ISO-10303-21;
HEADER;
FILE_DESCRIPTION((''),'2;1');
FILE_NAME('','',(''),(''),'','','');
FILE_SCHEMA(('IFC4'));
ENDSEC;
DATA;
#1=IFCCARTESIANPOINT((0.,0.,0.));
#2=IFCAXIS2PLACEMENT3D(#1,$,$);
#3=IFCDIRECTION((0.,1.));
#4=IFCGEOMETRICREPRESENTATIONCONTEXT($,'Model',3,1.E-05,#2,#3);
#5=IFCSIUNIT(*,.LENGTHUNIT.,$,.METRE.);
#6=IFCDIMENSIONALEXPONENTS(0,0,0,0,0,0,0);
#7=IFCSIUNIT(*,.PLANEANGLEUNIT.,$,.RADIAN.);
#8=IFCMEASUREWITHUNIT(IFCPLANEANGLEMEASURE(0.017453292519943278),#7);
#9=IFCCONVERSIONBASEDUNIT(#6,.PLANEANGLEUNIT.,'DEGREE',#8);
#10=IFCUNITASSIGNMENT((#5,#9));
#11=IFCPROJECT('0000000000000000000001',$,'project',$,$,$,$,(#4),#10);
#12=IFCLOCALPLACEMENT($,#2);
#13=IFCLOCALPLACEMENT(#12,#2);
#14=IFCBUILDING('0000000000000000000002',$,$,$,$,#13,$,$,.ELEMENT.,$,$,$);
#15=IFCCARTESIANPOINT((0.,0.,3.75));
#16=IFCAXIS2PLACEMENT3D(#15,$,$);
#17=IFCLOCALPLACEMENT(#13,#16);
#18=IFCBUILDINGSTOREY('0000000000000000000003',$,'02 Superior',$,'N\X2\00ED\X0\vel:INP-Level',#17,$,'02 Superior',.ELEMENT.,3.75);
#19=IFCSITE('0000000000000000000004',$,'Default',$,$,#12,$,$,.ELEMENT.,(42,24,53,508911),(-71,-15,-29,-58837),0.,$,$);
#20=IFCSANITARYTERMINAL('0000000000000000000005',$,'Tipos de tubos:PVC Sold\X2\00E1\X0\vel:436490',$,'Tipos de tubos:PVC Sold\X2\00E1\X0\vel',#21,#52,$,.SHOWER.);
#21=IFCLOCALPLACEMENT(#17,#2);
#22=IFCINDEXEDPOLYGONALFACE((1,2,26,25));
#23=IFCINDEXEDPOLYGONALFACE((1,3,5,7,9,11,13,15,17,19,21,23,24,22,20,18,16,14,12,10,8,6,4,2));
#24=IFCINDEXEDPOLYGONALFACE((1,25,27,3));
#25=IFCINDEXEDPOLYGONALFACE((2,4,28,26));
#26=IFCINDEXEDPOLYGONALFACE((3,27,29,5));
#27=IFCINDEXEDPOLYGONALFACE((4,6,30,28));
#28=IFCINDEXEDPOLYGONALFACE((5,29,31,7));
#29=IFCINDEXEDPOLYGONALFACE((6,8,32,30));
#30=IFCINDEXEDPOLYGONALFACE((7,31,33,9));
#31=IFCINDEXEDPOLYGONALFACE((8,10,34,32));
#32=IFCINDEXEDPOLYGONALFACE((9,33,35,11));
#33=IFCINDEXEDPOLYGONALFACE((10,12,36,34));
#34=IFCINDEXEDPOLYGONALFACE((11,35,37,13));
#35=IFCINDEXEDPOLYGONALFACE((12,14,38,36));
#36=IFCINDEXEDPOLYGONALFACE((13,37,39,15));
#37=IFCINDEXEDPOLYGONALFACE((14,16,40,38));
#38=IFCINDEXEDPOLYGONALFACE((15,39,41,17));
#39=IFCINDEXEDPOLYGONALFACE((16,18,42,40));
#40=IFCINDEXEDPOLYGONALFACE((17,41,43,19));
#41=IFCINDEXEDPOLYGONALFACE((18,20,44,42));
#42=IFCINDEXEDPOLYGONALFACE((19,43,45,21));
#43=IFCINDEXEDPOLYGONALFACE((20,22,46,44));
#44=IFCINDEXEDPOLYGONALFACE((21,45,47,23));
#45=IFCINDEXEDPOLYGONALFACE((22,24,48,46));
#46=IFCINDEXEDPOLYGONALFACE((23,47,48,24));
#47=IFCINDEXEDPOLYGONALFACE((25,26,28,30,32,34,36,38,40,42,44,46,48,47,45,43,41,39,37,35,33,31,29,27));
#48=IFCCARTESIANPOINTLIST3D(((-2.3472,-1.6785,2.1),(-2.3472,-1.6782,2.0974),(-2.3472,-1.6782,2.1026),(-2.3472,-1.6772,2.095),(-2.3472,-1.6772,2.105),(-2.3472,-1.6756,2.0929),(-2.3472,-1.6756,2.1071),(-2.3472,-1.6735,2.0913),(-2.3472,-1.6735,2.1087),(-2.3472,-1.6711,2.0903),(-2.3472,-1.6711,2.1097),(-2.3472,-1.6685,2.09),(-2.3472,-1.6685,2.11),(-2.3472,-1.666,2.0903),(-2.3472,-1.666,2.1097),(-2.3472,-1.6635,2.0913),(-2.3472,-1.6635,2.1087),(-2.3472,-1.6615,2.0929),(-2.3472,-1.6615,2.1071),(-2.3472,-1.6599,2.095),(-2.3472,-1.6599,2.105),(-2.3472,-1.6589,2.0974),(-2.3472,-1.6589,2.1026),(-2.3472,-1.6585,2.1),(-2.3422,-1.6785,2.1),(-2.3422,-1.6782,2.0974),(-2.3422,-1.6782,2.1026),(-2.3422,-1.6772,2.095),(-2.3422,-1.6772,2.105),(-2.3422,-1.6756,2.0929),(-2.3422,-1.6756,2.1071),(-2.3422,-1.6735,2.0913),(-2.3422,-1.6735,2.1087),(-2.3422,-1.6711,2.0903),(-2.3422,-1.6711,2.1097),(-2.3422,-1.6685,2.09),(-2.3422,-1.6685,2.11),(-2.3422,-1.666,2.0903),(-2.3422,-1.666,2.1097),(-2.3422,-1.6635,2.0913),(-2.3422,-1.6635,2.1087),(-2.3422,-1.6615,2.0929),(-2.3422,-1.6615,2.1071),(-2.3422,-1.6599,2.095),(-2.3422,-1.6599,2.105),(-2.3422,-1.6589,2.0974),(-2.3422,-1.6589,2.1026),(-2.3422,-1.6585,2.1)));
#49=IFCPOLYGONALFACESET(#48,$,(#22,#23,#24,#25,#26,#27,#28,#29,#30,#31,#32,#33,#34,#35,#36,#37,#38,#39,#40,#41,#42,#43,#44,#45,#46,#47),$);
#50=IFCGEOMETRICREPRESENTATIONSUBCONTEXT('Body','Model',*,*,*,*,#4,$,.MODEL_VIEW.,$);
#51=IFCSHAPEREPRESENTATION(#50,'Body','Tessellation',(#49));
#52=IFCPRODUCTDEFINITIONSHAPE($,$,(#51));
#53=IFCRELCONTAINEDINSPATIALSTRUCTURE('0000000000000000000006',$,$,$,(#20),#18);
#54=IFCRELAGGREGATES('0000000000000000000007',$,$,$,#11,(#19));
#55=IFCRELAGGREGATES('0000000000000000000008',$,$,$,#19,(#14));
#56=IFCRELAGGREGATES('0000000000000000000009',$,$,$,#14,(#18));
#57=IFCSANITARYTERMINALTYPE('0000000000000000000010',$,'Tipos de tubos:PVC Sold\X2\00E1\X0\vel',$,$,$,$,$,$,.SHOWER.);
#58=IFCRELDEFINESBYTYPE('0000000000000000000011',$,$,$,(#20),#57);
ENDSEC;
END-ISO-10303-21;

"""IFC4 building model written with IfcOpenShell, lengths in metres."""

from ifc_helpers import new_model, entity, si_unit, converted_unit, direction, frame, origin, place, context, subcontext, project, spatial, arc, indexed_curve, outline, extrude, type_object, element, save


model = new_model("IFC4")

# Units and contexts
model_context = context("Model", 3, precision=1e-05, world=origin(), true_north=direction((0.0, 1.0)))
body_context = subcontext(model_context, "Body", "Model", "MODEL_VIEW")
ifc_project = project(units=[si_unit("LENGTHUNIT", "METRE"), converted_unit("PLANEANGLEUNIT", "DEGREE", entity("IfcPlaneAngleMeasure", 0.017453292519943278), si_unit("PLANEANGLEUNIT", "RADIAN"), dimensions=[0, 0, 0, 0, 0, 0, 0])], contexts=[model_context])

# Site, building, storey
site_placement = place(None, origin())
site = spatial("IfcSite", under=ifc_project, at=site_placement, Name="Default", CompositionType="ELEMENT", RefLatitude=(42, 24, 53, 508911), RefLongitude=(-71, -15, -29, -58837), RefElevation=0.0)
building_placement = place(site_placement, origin())
building = spatial("IfcBuilding", under=site, at=building_placement, CompositionType="ELEMENT")
storey_placement = place(building_placement, frame((0.0, 0.0, 3.75)))
storey = spatial("IfcBuildingStorey", under=building, at=storey_placement, Name="02 Superior", ObjectType="Nível:INP-Level", LongName="02 Superior", CompositionType="ELEMENT", Elevation=3.75)

# Sanitary terminal
sanitary_terminal_type_1 = type_object("IfcSanitaryTerminalType", Name="Tipos de tubos:PVC Soldável", PredefinedType="SHOWER")
sanitary_terminal_1_placement = place(storey_placement, origin())
element("IfcSanitaryTerminal", 1, at=sanitary_terminal_1_placement, inside=storey, type_object=sanitary_terminal_type_1, Name="Tipos de tubos:PVC Soldável:436490", ObjectType="Tipos de tubos:PVC Soldável", PredefinedType="SHOWER", context=body_context, shape_type="SweptSolid", body=[
    extrude(outline(indexed_curve([(0.01, 0.0), (0.0071, 0.0071), (0.0, 0.01), (-0.0071, 0.0071), (-0.01, 0.0), (-0.0071, -0.0071), (0.0, -0.01), (0.0071, -0.0071)], segments=[arc(1, 2, 3), arc(3, 4, 5), arc(5, 6, 7), arc(7, 8, 1)], self_intersect=False)), frame((-2.3472, -1.6685, 2.1), z_axis=(1.0, 0.0, 0.0), x_axis=(0.0, -1.0, 0.0)), (0.0, 0.0, 1.0), 0.005),
])

save(model, "model.ifc")
